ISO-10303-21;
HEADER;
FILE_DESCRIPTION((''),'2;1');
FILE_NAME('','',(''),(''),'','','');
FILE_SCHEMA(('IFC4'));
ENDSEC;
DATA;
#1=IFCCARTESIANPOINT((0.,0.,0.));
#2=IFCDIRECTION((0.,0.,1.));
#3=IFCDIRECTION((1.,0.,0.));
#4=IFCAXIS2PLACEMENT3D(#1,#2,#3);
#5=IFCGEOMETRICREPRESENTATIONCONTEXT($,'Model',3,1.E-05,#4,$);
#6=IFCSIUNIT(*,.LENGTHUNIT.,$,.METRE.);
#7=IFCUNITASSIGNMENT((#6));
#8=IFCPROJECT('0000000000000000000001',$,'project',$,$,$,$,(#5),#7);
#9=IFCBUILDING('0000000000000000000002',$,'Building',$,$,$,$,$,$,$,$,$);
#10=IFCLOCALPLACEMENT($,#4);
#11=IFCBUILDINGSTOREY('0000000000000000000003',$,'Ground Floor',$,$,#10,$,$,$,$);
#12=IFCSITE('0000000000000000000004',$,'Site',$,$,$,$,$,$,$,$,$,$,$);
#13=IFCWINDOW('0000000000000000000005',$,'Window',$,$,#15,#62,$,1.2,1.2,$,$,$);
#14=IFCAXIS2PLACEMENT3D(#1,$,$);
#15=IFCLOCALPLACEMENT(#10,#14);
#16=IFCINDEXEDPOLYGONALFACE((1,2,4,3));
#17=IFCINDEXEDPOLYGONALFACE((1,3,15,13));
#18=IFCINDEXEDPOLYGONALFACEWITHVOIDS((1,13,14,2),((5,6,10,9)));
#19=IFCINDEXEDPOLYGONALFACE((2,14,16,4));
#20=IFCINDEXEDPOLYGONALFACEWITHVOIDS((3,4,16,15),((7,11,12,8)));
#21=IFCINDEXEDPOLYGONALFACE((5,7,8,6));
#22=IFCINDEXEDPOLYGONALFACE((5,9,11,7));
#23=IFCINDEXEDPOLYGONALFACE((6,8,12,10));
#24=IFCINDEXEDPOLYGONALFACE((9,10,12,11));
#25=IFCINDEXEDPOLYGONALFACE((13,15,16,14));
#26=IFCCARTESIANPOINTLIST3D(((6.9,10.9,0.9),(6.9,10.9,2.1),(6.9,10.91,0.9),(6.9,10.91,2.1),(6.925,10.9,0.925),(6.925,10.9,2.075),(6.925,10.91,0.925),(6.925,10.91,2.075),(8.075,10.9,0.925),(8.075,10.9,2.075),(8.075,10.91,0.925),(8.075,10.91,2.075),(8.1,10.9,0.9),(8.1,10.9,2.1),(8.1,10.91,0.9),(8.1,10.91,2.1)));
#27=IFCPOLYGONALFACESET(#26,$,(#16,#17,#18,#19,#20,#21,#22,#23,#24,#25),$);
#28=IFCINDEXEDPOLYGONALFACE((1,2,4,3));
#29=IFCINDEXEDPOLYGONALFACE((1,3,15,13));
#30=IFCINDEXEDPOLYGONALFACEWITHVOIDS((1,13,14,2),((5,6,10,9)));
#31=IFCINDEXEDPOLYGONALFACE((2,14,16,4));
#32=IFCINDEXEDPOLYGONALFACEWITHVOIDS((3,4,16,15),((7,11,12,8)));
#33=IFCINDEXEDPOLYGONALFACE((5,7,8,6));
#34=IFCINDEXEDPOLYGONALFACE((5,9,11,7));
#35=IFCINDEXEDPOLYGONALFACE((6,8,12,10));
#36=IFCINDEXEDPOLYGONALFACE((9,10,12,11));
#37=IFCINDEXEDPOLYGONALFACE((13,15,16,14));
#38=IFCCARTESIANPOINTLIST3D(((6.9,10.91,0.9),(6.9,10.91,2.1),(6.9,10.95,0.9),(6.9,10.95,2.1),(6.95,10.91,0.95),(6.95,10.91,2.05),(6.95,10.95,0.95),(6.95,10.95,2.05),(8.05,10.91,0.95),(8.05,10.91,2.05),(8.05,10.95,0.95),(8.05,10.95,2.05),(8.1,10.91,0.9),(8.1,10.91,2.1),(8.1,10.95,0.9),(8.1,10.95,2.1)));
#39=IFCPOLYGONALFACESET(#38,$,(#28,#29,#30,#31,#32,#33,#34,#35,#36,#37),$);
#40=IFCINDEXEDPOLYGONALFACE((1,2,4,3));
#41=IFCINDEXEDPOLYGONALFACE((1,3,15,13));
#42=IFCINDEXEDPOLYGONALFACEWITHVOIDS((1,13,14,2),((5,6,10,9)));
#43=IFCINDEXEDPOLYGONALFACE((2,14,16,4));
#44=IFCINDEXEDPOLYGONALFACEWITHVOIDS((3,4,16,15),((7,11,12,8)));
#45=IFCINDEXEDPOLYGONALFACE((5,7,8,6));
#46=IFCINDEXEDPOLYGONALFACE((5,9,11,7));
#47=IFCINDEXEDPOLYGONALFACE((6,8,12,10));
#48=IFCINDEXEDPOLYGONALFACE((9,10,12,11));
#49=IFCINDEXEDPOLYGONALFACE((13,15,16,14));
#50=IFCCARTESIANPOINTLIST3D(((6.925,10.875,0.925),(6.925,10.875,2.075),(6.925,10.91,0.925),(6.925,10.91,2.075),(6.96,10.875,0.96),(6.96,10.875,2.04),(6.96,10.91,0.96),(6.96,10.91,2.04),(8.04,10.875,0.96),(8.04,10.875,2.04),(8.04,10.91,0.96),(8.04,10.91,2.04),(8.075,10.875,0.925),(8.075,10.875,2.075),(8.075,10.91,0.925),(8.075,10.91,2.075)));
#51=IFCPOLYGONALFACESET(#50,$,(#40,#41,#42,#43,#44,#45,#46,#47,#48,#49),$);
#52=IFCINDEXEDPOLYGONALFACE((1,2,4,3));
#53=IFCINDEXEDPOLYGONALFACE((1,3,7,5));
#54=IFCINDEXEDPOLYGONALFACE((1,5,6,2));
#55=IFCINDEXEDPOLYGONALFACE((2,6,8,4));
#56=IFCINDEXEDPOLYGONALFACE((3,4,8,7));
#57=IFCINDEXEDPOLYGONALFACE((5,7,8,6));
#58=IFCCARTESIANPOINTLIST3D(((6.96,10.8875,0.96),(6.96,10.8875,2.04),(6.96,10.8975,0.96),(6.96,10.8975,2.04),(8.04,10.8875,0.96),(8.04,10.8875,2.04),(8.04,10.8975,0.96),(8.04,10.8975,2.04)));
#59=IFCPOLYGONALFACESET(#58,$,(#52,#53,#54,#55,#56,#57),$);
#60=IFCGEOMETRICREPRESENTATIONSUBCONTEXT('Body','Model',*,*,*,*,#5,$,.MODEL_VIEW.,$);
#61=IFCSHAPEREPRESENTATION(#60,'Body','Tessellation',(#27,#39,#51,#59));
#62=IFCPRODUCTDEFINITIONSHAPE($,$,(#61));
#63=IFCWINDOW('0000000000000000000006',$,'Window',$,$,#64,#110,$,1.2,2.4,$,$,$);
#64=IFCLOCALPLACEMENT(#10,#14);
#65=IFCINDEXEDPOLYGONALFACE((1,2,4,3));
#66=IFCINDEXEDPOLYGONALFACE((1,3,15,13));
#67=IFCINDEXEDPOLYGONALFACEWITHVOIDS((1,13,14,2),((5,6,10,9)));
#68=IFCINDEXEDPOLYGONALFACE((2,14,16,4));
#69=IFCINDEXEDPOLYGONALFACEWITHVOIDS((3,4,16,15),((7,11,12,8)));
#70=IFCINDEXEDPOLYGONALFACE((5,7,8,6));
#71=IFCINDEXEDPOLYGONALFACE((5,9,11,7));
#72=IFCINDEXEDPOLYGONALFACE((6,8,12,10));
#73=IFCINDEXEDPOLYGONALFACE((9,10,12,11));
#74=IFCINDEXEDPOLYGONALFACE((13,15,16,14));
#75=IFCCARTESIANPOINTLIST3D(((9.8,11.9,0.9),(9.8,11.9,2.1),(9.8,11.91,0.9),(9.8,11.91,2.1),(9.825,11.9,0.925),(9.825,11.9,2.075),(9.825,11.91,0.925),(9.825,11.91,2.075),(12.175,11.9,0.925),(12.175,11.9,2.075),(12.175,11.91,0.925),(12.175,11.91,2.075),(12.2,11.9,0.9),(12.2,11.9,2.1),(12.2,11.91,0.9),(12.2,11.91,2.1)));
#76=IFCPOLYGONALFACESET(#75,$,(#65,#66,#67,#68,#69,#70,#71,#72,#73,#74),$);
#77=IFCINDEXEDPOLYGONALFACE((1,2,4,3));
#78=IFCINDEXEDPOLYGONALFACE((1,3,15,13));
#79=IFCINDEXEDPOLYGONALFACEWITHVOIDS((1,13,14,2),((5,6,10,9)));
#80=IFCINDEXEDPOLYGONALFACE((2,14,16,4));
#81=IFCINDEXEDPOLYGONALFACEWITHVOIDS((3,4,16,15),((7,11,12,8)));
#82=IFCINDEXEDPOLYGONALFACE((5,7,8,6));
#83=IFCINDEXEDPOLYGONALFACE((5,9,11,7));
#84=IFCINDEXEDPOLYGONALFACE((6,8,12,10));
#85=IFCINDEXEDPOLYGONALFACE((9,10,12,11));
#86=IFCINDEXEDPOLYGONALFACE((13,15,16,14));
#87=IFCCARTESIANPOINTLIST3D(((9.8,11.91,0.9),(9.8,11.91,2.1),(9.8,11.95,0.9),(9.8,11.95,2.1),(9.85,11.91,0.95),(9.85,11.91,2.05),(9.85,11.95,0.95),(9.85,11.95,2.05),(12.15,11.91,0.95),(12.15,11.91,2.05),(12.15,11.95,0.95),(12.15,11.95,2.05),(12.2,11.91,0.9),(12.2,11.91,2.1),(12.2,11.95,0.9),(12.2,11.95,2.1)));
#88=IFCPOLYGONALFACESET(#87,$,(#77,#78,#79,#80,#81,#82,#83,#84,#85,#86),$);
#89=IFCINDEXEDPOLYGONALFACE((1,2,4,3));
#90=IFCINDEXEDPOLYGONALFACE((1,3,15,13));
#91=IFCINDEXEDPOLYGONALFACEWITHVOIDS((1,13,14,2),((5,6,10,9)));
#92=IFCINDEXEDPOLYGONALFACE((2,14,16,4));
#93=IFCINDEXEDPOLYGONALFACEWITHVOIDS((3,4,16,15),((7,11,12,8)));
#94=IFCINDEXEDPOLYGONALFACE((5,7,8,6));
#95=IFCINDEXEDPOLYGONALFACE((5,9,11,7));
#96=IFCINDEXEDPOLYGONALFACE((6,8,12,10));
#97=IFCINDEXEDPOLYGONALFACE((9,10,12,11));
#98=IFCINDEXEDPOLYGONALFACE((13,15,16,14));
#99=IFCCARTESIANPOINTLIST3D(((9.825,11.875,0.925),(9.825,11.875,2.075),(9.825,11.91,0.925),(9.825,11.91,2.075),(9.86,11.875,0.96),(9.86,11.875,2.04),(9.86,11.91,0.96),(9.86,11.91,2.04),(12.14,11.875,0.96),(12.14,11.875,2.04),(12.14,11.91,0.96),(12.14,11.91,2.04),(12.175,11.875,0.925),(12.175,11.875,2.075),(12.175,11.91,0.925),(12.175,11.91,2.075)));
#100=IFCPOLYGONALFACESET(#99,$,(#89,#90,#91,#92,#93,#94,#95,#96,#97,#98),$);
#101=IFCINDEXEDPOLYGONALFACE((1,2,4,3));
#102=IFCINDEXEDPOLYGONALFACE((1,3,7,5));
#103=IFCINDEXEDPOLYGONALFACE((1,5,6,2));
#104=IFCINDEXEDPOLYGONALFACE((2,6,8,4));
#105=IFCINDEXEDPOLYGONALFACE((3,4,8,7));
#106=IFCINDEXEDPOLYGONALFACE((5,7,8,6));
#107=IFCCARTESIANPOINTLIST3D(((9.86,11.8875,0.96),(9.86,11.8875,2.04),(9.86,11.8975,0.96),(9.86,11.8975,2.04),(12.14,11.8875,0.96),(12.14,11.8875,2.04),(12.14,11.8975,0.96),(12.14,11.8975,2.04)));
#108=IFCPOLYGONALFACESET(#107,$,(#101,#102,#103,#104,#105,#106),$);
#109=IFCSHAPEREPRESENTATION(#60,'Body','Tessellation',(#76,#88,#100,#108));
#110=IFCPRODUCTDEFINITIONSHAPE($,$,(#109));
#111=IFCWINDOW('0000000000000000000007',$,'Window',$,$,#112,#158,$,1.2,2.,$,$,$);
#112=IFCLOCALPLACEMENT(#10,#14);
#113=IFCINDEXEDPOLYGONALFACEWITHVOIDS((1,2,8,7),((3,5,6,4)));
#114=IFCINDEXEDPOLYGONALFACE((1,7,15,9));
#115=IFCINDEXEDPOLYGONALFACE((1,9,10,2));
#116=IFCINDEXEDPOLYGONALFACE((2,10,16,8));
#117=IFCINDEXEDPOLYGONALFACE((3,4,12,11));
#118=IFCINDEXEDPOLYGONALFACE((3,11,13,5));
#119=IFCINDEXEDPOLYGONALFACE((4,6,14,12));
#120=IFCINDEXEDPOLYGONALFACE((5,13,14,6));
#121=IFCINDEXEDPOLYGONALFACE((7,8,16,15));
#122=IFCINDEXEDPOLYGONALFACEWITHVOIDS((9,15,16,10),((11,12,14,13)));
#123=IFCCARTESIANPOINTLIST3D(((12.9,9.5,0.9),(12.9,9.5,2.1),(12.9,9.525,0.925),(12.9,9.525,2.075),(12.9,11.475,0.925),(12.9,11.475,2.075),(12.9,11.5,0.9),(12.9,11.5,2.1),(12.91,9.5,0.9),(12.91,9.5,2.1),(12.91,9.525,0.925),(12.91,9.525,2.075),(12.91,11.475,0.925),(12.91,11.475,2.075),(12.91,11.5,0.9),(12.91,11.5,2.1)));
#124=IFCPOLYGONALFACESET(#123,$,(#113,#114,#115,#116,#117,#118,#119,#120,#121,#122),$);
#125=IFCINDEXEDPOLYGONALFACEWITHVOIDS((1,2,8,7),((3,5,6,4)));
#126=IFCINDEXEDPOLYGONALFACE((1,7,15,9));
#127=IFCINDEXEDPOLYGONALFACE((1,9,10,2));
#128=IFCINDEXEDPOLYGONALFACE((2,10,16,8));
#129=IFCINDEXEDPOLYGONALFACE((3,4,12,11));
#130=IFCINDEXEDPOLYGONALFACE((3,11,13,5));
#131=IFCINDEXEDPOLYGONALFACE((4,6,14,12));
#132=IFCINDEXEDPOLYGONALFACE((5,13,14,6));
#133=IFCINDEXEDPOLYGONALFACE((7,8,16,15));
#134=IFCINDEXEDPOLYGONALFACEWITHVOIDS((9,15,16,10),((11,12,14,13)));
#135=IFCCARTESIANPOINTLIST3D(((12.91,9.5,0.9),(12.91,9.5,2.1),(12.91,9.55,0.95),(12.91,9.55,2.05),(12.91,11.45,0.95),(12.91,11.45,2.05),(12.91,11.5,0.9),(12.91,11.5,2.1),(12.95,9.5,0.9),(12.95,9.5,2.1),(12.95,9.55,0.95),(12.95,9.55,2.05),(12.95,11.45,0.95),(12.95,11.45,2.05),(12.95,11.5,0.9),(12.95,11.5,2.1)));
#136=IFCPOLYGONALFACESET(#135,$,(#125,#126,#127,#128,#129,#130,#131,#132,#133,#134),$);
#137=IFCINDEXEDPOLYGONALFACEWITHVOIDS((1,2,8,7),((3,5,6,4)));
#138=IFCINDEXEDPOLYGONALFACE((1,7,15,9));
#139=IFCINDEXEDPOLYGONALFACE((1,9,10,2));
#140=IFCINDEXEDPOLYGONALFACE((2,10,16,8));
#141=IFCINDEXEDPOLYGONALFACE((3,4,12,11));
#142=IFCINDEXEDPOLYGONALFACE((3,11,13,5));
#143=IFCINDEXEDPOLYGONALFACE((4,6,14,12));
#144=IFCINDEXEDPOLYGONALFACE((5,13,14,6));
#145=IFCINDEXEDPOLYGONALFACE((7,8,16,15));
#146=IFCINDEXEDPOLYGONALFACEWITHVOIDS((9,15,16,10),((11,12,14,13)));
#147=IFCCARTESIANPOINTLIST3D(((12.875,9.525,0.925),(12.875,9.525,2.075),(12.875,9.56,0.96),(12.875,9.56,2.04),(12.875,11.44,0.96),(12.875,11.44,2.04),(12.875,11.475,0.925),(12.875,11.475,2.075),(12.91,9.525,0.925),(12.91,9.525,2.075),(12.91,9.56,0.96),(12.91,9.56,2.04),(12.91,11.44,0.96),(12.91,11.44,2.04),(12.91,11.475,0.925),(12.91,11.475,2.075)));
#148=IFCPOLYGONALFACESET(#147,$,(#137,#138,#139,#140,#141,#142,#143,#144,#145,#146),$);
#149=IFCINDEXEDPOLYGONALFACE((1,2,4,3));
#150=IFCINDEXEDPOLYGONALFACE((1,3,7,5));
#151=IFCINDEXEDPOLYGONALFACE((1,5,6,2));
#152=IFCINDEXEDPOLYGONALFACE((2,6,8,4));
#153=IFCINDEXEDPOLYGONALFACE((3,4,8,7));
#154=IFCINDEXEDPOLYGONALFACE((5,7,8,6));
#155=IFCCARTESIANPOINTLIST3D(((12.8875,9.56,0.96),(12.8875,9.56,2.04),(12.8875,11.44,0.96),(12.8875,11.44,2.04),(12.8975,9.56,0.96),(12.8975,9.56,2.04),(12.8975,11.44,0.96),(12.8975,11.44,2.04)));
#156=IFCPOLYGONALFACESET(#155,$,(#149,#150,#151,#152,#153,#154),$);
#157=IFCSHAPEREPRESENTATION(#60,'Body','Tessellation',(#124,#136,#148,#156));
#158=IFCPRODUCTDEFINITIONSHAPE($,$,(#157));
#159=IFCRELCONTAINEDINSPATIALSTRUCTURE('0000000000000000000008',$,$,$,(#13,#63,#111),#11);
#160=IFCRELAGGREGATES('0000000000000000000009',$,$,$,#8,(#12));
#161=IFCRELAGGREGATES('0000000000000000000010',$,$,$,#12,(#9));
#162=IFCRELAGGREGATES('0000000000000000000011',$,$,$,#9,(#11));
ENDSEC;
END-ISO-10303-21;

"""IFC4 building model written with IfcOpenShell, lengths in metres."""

from ifc_helpers import new_model, si_unit, frame, origin_with_axes, place, context, subcontext, project, spatial, line, indexed_curve, outline, extrude, element, save


model = new_model("IFC4")

# Units and contexts
model_context = context("Model", 3, precision=1e-05, world=origin_with_axes())
body_context = subcontext(model_context, "Body", "Model", "MODEL_VIEW")
ifc_project = project(units=[si_unit("LENGTHUNIT", "METRE")], contexts=[model_context])

# Site, building, storey
site = spatial("IfcSite", under=ifc_project, Name="Site")
building = spatial("IfcBuilding", under=site, Name="Building")
storey_placement = place(None, origin_with_axes())
storey = spatial("IfcBuildingStorey", under=building, at=storey_placement, Name="Ground Floor")

# Windows
window_1_placement = place(storey_placement, frame((8.1, 11.0, 0.9), z_axis=(0.0, 0.0, 1.0), x_axis=(-1.0, 0.0, 0.0)))
element("IfcWindow", 1, at=window_1_placement, inside=storey, Name="Window", OverallHeight=1.2, OverallWidth=1.2, context=body_context, shape_type="SweptSolid", body=[
    extrude(outline(indexed_curve([(0.0, 0.0), (1.2, 0.0), (1.2, 1.2), (0.0, 1.2)], segments=[line(1, 2, 3, 4, 1)]), holes=[indexed_curve([(0.025, 0.025), (1.175, 0.025), (1.175, 1.175), (0.025, 1.175)], segments=[line(1, 2, 3, 4, 1)])]), frame((0.0, 0.09, 0.0), z_axis=(0.0, -1.0, 0.0), x_axis=(1.0, 0.0, 0.0)), (0.0, 0.0, -1.0), 0.01),
    extrude(outline(indexed_curve([(0.0, 0.0), (1.2, 0.0), (1.2, 1.2), (0.0, 1.2)], segments=[line(1, 2, 3, 4, 1)]), holes=[indexed_curve([(0.05, 0.05), (1.15, 0.05), (1.15, 1.15), (0.05, 1.15)], segments=[line(1, 2, 3, 4, 1)])]), frame((0.0, 0.05, 0.0), z_axis=(0.0, -1.0, 0.0), x_axis=(1.0, 0.0, 0.0)), (0.0, 0.0, -1.0), 0.04),
    extrude(outline(indexed_curve([(0.0, 0.0), (1.15, 0.0), (1.15, 1.15), (0.0, 1.15)], segments=[line(1, 2, 3, 4, 1)]), holes=[indexed_curve([(0.035, 0.035), (1.115, 0.035), (1.115, 1.115), (0.035, 1.115)], segments=[line(1, 2, 3, 4, 1)])]), frame((0.025, 0.09, 0.025), z_axis=(0.0, -1.0, 0.0), x_axis=(1.0, 0.0, 0.0)), (0.0, 0.0, -1.0), 0.035),
    extrude(outline(indexed_curve([(0.035, 0.035), (1.115, 0.035), (1.115, 1.115), (0.035, 1.115)], segments=[line(1, 2, 3, 4, 1)])), frame((0.025, 0.1025, 0.025), z_axis=(0.0, -1.0, 0.0), x_axis=(1.0, 0.0, 0.0)), (0.0, 0.0, -1.0), 0.01),
])
window_2_placement = place(storey_placement, frame((12.2, 12.0, 0.9), z_axis=(0.0, 0.0, 1.0), x_axis=(-1.0, 0.0, 0.0)))
element("IfcWindow", 2, at=window_2_placement, inside=storey, Name="Window", OverallHeight=1.2, OverallWidth=2.4, context=body_context, shape_type="SweptSolid", body=[
    extrude(outline(indexed_curve([(0.0, 0.0), (2.4, 0.0), (2.4, 1.2), (0.0, 1.2)], segments=[line(1, 2, 3, 4, 1)]), holes=[indexed_curve([(0.025, 0.025), (2.375, 0.025), (2.375, 1.175), (0.025, 1.175)], segments=[line(1, 2, 3, 4, 1)])]), frame((0.0, 0.09, 0.0), z_axis=(0.0, -1.0, 0.0), x_axis=(1.0, 0.0, 0.0)), (0.0, 0.0, -1.0), 0.01),
    extrude(outline(indexed_curve([(0.0, 0.0), (2.4, 0.0), (2.4, 1.2), (0.0, 1.2)], segments=[line(1, 2, 3, 4, 1)]), holes=[indexed_curve([(0.05, 0.05), (2.35, 0.05), (2.35, 1.15), (0.05, 1.15)], segments=[line(1, 2, 3, 4, 1)])]), frame((0.0, 0.05, 0.0), z_axis=(0.0, -1.0, 0.0), x_axis=(1.0, 0.0, 0.0)), (0.0, 0.0, -1.0), 0.04),
    extrude(outline(indexed_curve([(0.0, 0.0), (2.35, 0.0), (2.35, 1.15), (0.0, 1.15)], segments=[line(1, 2, 3, 4, 1)]), holes=[indexed_curve([(0.035, 0.035), (2.315, 0.035), (2.315, 1.115), (0.035, 1.115)], segments=[line(1, 2, 3, 4, 1)])]), frame((0.025, 0.09, 0.025), z_axis=(0.0, -1.0, 0.0), x_axis=(1.0, 0.0, 0.0)), (0.0, 0.0, -1.0), 0.035),
    extrude(outline(indexed_curve([(0.035, 0.035), (2.315, 0.035), (2.315, 1.115), (0.035, 1.115)], segments=[line(1, 2, 3, 4, 1)])), frame((0.025, 0.1025, 0.025), z_axis=(0.0, -1.0, 0.0), x_axis=(1.0, 0.0, 0.0)), (0.0, 0.0, -1.0), 0.01),
])
window_3_placement = place(storey_placement, frame((13.0, 9.5, 0.9), z_axis=(0.0, 0.0, 1.0), x_axis=(0.0, 1.0, 0.0)))
element("IfcWindow", 3, at=window_3_placement, inside=storey, Name="Window", OverallHeight=1.2, OverallWidth=2.0, context=body_context, shape_type="SweptSolid", body=[
    extrude(outline(indexed_curve([(0.0, 0.0), (2.0, 0.0), (2.0, 1.2), (0.0, 1.2)], segments=[line(1, 2, 3, 4, 1)]), holes=[indexed_curve([(0.025, 0.025), (1.975, 0.025), (1.975, 1.175), (0.025, 1.175)], segments=[line(1, 2, 3, 4, 1)])]), frame((0.0, 0.09, 0.0), z_axis=(0.0, -1.0, 0.0), x_axis=(1.0, 0.0, 0.0)), (0.0, 0.0, -1.0), 0.01),
    extrude(outline(indexed_curve([(0.0, 0.0), (2.0, 0.0), (2.0, 1.2), (0.0, 1.2)], segments=[line(1, 2, 3, 4, 1)]), holes=[indexed_curve([(0.05, 0.05), (1.95, 0.05), (1.95, 1.15), (0.05, 1.15)], segments=[line(1, 2, 3, 4, 1)])]), frame((0.0, 0.05, 0.0), z_axis=(0.0, -1.0, 0.0), x_axis=(1.0, 0.0, 0.0)), (0.0, 0.0, -1.0), 0.04),
    extrude(outline(indexed_curve([(0.0, 0.0), (1.95, 0.0), (1.95, 1.15), (0.0, 1.15)], segments=[line(1, 2, 3, 4, 1)]), holes=[indexed_curve([(0.035, 0.035), (1.915, 0.035), (1.915, 1.115), (0.035, 1.115)], segments=[line(1, 2, 3, 4, 1)])]), frame((0.025, 0.09, 0.025), z_axis=(0.0, -1.0, 0.0), x_axis=(1.0, 0.0, 0.0)), (0.0, 0.0, -1.0), 0.035),
    extrude(outline(indexed_curve([(0.035, 0.035), (1.915, 0.035), (1.915, 1.115), (0.035, 1.115)], segments=[line(1, 2, 3, 4, 1)])), frame((0.025, 0.1025, 0.025), z_axis=(0.0, -1.0, 0.0), x_axis=(1.0, 0.0, 0.0)), (0.0, 0.0, -1.0), 0.01),
])

save(model, "model.ifc")
